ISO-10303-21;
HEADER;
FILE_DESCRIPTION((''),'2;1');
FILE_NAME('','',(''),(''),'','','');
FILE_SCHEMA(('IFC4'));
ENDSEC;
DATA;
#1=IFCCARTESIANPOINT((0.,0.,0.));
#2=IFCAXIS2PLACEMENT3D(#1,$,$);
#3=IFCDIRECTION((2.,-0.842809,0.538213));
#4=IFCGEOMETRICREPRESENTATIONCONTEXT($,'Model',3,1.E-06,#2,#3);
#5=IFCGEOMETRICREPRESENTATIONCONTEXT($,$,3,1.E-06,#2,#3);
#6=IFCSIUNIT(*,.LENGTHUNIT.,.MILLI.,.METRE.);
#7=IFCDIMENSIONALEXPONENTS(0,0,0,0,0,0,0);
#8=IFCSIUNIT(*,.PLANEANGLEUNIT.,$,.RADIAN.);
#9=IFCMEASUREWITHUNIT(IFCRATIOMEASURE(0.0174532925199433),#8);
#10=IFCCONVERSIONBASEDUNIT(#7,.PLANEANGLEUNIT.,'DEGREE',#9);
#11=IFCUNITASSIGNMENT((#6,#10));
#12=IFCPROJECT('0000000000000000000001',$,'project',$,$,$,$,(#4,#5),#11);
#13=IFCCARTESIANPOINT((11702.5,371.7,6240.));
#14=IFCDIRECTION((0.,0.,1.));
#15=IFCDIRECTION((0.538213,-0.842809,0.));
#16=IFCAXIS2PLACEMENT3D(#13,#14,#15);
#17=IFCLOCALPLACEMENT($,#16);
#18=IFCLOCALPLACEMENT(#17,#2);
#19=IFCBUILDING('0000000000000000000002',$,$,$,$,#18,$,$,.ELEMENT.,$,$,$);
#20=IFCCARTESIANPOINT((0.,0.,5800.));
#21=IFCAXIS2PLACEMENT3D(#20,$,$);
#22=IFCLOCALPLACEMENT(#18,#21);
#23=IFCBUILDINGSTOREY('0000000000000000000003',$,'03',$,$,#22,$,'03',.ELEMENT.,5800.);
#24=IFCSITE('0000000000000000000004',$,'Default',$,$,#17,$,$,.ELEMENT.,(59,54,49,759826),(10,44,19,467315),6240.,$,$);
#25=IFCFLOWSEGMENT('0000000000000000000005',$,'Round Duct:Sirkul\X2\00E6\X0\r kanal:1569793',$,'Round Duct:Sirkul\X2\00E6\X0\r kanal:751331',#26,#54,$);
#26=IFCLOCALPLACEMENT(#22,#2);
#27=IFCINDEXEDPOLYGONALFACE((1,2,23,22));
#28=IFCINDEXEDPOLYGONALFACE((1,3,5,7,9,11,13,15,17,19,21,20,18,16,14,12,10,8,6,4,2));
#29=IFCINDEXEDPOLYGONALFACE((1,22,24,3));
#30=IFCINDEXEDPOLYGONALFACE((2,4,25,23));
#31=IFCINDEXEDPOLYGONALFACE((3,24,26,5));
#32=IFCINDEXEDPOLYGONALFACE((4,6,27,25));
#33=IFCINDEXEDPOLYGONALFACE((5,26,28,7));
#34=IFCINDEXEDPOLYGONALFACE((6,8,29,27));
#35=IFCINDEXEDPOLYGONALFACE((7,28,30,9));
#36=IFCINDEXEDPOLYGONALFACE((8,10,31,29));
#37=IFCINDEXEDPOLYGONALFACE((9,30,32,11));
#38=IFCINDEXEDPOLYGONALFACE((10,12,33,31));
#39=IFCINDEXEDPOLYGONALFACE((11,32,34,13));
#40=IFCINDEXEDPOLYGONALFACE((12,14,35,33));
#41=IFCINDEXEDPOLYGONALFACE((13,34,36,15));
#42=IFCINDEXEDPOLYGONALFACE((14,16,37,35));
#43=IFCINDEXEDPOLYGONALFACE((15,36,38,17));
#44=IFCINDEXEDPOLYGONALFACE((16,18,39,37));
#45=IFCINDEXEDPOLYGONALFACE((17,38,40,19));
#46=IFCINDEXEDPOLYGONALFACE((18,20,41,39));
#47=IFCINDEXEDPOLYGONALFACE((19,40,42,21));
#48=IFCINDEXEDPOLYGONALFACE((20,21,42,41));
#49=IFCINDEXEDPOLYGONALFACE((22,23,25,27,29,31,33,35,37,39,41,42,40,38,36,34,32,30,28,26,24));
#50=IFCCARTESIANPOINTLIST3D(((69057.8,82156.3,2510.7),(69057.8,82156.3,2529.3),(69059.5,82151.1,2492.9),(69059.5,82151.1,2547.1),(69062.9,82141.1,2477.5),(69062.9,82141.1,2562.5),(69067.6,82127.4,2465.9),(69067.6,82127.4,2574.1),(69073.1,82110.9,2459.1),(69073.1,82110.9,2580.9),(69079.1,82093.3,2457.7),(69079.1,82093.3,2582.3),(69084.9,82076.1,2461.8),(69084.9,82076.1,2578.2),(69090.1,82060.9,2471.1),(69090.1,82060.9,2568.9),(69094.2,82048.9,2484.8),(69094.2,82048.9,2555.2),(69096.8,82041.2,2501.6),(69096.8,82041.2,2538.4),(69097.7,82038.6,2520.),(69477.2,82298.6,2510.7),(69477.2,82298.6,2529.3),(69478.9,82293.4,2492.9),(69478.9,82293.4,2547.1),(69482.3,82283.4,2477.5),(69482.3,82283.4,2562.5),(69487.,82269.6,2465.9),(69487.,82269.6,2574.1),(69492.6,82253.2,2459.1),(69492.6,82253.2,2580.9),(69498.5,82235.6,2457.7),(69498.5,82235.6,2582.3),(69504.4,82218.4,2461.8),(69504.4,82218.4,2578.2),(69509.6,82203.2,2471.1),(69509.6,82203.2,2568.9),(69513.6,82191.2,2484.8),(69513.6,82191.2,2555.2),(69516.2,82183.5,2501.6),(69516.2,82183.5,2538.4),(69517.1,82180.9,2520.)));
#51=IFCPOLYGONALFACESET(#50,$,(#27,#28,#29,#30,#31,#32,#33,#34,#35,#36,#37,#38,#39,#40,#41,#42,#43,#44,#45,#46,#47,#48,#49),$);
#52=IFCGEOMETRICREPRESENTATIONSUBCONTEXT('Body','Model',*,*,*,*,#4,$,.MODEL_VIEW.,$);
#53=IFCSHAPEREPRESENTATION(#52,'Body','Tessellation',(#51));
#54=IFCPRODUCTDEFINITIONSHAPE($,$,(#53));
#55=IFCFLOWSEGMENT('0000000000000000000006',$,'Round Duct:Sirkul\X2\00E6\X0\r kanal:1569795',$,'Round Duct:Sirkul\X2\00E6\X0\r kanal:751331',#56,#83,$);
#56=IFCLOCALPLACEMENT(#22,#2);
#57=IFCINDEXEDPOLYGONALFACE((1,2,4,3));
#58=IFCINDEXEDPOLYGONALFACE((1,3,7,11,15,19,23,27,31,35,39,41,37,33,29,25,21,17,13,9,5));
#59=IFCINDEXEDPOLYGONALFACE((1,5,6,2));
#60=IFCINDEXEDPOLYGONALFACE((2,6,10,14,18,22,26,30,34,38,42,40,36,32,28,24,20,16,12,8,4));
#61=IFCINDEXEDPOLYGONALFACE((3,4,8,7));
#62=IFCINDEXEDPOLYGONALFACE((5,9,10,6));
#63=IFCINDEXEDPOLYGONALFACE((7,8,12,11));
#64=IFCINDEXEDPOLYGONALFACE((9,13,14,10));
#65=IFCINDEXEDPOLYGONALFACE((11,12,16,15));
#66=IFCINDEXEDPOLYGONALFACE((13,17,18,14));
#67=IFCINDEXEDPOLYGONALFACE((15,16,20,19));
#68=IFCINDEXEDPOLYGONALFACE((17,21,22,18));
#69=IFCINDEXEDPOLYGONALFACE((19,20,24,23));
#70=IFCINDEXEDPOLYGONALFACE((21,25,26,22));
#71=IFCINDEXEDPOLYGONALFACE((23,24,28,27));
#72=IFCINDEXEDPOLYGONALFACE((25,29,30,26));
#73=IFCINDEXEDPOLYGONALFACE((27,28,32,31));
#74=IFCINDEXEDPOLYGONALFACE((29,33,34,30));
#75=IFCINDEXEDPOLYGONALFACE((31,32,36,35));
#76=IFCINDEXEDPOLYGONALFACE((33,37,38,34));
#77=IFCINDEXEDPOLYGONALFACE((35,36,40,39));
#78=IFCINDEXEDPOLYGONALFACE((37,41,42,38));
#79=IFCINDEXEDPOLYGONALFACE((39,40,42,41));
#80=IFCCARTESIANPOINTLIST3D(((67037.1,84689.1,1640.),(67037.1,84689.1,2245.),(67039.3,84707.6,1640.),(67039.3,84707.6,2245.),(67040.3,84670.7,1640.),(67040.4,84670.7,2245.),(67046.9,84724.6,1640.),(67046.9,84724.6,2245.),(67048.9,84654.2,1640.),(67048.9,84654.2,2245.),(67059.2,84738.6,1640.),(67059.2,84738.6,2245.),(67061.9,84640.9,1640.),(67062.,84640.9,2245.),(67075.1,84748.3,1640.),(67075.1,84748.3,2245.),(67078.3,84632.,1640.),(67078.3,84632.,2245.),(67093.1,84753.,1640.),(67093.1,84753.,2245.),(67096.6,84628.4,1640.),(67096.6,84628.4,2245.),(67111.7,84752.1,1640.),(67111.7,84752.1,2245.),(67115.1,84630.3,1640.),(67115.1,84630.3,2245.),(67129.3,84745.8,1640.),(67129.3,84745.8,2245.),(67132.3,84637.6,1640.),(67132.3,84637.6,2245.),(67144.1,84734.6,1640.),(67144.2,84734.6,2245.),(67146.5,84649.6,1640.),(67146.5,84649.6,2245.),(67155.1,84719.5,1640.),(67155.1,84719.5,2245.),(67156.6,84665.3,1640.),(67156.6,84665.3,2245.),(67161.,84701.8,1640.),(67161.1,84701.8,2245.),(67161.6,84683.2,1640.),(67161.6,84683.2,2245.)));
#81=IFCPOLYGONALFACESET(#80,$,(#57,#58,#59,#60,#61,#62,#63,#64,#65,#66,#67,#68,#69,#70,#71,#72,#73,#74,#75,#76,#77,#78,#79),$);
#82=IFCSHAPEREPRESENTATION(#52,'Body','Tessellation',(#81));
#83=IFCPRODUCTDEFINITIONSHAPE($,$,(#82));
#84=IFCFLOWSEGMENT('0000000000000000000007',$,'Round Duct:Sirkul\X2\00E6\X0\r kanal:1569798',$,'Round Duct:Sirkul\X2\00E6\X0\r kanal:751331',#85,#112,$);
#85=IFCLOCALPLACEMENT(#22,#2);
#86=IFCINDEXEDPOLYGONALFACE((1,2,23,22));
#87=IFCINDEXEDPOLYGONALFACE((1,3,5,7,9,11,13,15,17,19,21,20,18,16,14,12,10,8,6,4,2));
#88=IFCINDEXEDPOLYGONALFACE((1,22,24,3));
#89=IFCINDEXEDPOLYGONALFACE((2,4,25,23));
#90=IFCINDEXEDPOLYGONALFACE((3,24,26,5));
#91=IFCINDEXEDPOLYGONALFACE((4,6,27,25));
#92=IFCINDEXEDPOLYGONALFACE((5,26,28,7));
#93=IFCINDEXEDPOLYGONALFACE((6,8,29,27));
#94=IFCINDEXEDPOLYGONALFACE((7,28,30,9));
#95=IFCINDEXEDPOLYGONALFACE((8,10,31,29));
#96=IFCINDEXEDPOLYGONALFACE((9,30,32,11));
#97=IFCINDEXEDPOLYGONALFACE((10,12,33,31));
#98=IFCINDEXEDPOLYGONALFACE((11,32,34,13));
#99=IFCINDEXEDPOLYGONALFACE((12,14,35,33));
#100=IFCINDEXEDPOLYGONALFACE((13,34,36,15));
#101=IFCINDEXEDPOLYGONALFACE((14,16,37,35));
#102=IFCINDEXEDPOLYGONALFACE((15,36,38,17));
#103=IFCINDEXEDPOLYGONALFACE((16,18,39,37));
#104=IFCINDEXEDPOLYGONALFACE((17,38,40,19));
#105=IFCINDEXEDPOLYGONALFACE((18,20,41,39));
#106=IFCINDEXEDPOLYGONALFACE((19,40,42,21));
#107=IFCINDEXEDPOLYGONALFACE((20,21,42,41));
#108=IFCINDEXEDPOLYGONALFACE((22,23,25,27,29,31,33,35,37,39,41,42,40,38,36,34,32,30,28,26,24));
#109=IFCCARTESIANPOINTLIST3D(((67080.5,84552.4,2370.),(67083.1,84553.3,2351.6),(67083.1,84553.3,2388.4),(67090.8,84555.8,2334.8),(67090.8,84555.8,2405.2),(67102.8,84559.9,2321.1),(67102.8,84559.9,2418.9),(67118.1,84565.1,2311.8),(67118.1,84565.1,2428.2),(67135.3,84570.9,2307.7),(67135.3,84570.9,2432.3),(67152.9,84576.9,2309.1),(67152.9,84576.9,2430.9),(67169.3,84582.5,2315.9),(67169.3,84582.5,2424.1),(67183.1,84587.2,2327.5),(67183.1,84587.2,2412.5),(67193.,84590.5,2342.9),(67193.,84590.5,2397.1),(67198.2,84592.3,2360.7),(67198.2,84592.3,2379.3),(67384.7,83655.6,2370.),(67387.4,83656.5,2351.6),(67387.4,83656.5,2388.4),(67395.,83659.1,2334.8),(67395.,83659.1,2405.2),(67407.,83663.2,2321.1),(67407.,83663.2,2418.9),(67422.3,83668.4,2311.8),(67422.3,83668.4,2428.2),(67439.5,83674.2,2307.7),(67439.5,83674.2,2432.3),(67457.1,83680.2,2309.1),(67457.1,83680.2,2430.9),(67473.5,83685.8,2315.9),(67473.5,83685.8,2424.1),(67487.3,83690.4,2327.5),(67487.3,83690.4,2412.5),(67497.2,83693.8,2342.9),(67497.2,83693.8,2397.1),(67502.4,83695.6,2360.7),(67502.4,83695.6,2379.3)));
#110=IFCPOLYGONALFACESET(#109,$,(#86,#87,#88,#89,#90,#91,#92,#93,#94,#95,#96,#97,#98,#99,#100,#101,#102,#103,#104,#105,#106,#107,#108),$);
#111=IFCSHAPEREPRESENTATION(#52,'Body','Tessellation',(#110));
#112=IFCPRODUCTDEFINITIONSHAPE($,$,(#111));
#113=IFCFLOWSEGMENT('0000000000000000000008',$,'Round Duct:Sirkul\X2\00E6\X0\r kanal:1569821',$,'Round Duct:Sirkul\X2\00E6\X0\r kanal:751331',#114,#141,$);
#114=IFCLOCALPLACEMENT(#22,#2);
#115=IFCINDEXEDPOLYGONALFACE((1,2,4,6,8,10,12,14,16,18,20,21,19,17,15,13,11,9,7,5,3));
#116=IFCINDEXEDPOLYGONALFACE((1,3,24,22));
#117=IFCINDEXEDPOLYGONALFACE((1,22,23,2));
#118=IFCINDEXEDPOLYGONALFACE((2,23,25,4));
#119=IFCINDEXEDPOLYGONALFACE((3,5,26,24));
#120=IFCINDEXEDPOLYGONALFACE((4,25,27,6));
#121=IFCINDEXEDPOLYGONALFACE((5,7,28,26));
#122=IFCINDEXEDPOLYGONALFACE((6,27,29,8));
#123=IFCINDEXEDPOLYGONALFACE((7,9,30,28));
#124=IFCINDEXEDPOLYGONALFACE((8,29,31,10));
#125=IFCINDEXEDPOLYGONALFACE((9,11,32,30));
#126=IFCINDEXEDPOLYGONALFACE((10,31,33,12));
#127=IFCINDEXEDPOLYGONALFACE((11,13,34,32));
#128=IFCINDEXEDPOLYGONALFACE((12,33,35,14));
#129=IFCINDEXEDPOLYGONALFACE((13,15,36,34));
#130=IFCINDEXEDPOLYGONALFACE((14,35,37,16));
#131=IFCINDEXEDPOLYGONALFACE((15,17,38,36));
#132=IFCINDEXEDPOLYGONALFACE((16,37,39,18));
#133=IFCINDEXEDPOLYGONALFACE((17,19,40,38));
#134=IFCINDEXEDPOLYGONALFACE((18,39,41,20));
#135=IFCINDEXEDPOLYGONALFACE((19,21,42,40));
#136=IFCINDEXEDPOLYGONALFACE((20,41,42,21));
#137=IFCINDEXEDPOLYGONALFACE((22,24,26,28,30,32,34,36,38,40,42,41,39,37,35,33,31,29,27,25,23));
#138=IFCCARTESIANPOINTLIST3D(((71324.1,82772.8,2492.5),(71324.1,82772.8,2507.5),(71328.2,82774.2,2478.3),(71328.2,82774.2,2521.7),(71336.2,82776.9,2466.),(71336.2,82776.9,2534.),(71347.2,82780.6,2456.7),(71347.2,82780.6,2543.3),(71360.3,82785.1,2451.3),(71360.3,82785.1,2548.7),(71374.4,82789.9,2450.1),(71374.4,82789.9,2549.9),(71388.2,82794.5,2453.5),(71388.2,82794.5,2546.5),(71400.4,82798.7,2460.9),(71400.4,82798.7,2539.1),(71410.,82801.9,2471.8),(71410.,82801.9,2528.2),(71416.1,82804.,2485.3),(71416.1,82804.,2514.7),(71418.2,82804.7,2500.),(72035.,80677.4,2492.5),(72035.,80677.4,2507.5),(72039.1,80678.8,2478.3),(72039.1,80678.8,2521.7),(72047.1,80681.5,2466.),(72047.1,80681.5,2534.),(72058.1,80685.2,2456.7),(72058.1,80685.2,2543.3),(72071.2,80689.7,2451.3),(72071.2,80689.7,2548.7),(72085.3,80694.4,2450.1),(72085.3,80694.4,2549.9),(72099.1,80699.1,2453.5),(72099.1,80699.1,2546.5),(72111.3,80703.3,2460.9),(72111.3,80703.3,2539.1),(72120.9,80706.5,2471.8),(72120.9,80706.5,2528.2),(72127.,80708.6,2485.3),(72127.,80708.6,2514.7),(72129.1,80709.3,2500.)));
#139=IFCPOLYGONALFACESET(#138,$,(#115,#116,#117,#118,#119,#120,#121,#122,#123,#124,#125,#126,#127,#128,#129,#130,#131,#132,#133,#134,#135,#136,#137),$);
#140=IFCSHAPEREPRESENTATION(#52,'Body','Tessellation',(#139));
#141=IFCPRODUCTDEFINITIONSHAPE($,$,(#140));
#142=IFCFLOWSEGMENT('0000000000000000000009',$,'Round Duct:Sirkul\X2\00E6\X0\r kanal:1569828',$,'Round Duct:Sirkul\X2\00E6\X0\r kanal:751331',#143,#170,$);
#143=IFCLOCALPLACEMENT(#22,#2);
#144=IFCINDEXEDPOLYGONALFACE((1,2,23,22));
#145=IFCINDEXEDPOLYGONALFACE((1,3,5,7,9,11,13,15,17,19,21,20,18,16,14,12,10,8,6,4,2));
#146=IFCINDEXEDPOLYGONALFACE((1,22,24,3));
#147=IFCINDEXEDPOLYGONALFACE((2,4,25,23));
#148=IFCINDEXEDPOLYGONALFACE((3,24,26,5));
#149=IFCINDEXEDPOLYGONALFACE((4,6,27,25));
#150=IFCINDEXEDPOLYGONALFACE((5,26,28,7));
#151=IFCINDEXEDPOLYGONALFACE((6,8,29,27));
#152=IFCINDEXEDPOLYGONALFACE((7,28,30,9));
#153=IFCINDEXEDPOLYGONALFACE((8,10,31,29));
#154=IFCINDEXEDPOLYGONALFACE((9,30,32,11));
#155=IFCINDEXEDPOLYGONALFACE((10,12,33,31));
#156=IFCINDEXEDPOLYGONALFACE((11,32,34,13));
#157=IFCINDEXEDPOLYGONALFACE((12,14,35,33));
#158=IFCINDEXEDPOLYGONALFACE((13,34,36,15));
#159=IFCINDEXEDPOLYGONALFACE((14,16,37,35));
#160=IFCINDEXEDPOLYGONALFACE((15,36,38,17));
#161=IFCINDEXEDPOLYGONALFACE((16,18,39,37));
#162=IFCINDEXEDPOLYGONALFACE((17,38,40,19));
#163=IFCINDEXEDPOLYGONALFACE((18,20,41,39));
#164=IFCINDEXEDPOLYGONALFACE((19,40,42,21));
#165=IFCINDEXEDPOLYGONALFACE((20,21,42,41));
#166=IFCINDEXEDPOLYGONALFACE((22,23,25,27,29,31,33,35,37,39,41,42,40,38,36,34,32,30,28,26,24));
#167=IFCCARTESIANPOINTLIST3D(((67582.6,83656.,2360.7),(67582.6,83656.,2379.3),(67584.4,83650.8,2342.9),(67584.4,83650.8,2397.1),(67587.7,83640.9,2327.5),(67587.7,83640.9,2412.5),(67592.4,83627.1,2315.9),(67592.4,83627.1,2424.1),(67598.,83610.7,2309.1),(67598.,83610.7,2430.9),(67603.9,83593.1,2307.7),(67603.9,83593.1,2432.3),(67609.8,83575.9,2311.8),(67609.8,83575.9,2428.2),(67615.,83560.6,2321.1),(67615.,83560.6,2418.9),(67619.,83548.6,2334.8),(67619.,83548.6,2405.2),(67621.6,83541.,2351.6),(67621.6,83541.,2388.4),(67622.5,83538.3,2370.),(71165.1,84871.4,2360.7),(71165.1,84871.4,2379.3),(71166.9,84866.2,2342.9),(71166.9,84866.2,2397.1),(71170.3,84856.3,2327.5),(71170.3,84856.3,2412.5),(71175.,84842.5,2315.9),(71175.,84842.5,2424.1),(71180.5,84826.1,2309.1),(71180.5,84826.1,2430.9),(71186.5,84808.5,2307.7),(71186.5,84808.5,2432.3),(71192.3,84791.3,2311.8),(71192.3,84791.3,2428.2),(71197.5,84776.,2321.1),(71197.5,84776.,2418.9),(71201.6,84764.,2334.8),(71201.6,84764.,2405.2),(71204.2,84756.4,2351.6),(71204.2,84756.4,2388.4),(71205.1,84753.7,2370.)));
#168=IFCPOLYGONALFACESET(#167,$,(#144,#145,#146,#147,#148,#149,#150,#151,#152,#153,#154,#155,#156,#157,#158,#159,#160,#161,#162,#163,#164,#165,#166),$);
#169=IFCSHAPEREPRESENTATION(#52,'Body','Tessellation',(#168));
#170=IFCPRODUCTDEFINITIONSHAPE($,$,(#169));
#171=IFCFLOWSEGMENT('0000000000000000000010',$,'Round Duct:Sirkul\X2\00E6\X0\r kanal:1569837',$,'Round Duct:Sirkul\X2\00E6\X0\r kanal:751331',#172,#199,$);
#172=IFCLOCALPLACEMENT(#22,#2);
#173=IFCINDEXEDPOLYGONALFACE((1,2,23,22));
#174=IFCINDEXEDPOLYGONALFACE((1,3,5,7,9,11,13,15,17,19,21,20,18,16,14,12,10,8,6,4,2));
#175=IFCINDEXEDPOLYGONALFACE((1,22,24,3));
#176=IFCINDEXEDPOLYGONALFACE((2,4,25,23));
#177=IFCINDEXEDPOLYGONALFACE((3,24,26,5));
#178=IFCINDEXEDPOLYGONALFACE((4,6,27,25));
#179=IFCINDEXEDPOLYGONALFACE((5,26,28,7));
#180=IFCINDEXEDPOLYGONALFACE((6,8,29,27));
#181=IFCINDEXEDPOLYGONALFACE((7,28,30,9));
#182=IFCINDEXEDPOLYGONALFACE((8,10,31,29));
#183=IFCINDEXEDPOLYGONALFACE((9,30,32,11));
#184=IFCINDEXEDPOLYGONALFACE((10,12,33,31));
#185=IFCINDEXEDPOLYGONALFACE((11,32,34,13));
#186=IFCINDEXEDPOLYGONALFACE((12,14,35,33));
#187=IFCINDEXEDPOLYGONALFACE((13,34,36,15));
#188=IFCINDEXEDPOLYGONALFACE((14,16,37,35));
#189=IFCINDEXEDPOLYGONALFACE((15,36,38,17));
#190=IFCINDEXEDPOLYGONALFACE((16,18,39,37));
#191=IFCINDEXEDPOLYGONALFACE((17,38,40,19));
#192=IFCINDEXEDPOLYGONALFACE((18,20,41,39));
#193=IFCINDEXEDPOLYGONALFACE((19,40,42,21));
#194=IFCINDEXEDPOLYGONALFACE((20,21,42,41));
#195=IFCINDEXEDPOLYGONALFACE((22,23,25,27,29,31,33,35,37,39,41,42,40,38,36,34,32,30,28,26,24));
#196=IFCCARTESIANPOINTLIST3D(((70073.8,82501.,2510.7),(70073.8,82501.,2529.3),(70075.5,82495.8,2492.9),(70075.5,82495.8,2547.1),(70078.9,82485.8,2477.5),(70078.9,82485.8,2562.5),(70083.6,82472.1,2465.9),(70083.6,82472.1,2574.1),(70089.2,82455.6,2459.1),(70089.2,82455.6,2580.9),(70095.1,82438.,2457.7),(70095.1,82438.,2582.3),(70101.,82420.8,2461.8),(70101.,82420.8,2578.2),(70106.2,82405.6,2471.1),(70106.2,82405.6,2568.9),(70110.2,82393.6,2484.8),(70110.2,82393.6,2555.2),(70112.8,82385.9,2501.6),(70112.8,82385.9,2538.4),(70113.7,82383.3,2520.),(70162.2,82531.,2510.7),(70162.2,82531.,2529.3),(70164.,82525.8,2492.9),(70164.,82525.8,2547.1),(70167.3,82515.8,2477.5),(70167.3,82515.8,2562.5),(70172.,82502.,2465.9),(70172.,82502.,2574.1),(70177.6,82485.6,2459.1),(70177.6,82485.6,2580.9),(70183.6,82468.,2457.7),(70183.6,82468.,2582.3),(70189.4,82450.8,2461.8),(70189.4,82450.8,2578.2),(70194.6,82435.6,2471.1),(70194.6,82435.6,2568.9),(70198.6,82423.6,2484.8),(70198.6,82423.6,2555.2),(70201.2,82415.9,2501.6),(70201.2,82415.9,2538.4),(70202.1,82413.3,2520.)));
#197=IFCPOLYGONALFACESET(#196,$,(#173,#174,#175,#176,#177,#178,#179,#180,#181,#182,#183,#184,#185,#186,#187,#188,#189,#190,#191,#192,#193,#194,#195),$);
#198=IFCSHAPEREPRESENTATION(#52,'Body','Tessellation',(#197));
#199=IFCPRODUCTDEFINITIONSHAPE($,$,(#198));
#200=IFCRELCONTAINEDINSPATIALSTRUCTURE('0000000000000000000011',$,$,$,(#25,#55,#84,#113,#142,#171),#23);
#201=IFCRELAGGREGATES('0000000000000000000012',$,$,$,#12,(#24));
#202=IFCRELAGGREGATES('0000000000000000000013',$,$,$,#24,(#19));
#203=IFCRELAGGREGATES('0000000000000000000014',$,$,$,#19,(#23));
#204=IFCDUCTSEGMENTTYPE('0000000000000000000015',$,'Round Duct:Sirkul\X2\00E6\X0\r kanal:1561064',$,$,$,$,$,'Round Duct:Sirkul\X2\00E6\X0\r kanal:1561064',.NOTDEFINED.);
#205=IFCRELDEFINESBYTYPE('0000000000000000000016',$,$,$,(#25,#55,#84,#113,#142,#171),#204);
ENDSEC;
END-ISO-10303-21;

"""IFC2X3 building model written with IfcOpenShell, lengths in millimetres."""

from ifc_helpers import new_model, entity, si_unit, converted_unit, direction, frame, frame_2d, origin, origin_2d_with_axis, place, context, subcontext, project, spatial, circle, extrude, type_object, element, save


model = new_model("IFC2X3")

# Units and contexts
model_context = context("Model", 3, precision=1e-06, world=origin(), true_north=direction((2.0, -0.842809, 0.538213)))
context_of_model = context(None, 3, precision=1e-06, world=origin(), true_north=direction((2.0, -0.842809, 0.538213)))
body_context = subcontext(model_context, "Body", "Model", "MODEL_VIEW")
ifc_project = project(units=[si_unit("LENGTHUNIT", "METRE", prefix="MILLI"), converted_unit("PLANEANGLEUNIT", "DEGREE", entity("IfcRatioMeasure", 0.0174532925199433), si_unit("PLANEANGLEUNIT", "RADIAN"), dimensions=[0, 0, 0, 0, 0, 0, 0])], contexts=[model_context, context_of_model])

# Site, building, storey
site_placement = place(None, frame((11702.5, 371.7, 6240.0), z_axis=(0.0, 0.0, 1.0), x_axis=(0.538213, -0.842809, 0.0)))
site = spatial("IfcSite", under=ifc_project, at=site_placement, Name="Default", CompositionType="ELEMENT", RefLatitude=(59, 54, 49, 759826), RefLongitude=(10, 44, 19, 467315), RefElevation=6240.0)
building_placement = place(site_placement, origin())
building = spatial("IfcBuilding", under=site, at=building_placement, CompositionType="ELEMENT")
storey_placement = place(building_placement, frame((0.0, 0.0, 5800.0)))
storey = spatial("IfcBuildingStorey", under=building, at=storey_placement, Name="03", LongName="03", CompositionType="ELEMENT", Elevation=5800.0)

# Flow segments
duct_segment_type = type_object("IfcDuctSegmentType", Name="Round Duct:Sirkulær kanal:1561064", ElementType="Round Duct:Sirkulær kanal:1561064", PredefinedType="NOTDEFINED")
flow_segment_1_placement = place(storey_placement, origin())
element("IfcFlowSegment", 1, at=flow_segment_1_placement, inside=storey, type_object=duct_segment_type, Name="Round Duct:Sirkulær kanal:1569793", ObjectType="Round Duct:Sirkulær kanal:751331", context=body_context, shape_type="SweptSolid", body=[
    extrude(circle(Radius=62.5, at=origin_2d_with_axis()), frame((69077.6, 82097.8, 2520.0), z_axis=(0.946986, 0.321274, 0.0), x_axis=(0.321274, -0.946986, 0.0)), (0.0, 0.0, 1.0), 442.9),
])
flow_segment_2_placement = place(storey_placement, origin())
element("IfcFlowSegment", 2, at=flow_segment_2_placement, inside=storey, type_object=duct_segment_type, Name="Round Duct:Sirkulær kanal:1569795", ObjectType="Round Duct:Sirkulær kanal:751331", context=body_context, shape_type="SweptSolid", body=[
    extrude(circle(Radius=62.5, at=frame_2d((0.0, 0.0), x_axis=(1.0, 0.0))), frame((67099.5, 84690.8, 1640.0), z_axis=(0.000028, 0.000009, 1.0), x_axis=(-0.946968, -0.321326, 0.000029)), (0.0, 0.0, 1.0), 605.0),
])
flow_segment_3_placement = place(storey_placement, origin())
element("IfcFlowSegment", 3, at=flow_segment_3_placement, inside=storey, type_object=duct_segment_type, Name="Round Duct:Sirkulær kanal:1569798", ObjectType="Round Duct:Sirkulær kanal:751331", context=body_context, shape_type="SweptSolid", body=[
    extrude(circle(Radius=62.5, at=origin_2d_with_axis()), frame((67443.9, 83675.7, 2370.0), z_axis=(-0.321267, 0.946988, 0.0), x_axis=(-0.946988, -0.321267, 0.0)), (0.0, 0.0, 1.0), 946.9),
])
flow_segment_4_placement = place(storey_placement, origin())
element("IfcFlowSegment", 4, at=flow_segment_4_placement, inside=storey, type_object=duct_segment_type, Name="Round Duct:Sirkulær kanal:1569821", ObjectType="Round Duct:Sirkulær kanal:751331", context=body_context, shape_type="SweptSolid", body=[
    extrude(circle(Radius=50.0, at=origin_2d_with_axis()), frame((71370.9, 82788.7, 2500.0), z_axis=(0.321274, -0.946986, 0.0), x_axis=(0.946986, 0.321274, 0.0)), (0.0, 0.0, 1.0), 2212.7),
])
flow_segment_5_placement = place(storey_placement, origin())
element("IfcFlowSegment", 5, at=flow_segment_5_placement, inside=storey, type_object=duct_segment_type, Name="Round Duct:Sirkulær kanal:1569828", ObjectType="Round Duct:Sirkulær kanal:751331", context=body_context, shape_type="SweptSolid", body=[
    extrude(circle(Radius=62.5, at=origin_2d_with_axis()), frame((67602.4, 83597.5, 2370.0), z_axis=(0.946986, 0.321274, 0.0), x_axis=(0.321274, -0.946986, 0.0)), (0.0, 0.0, 1.0), 3783.1),
])
flow_segment_6_placement = place(storey_placement, origin())
element("IfcFlowSegment", 6, at=flow_segment_6_placement, inside=storey, type_object=duct_segment_type, Name="Round Duct:Sirkulær kanal:1569837", ObjectType="Round Duct:Sirkulær kanal:751331", context=body_context, shape_type="SweptSolid", body=[
    extrude(circle(Radius=62.5, at=origin_2d_with_axis()), frame((70093.6, 82442.5, 2520.0), z_axis=(0.946986, 0.321274, 0.0), x_axis=(0.321274, -0.946986, 0.0)), (0.0, 0.0, 1.0), 93.4),
])

save(model, "model.ifc")
